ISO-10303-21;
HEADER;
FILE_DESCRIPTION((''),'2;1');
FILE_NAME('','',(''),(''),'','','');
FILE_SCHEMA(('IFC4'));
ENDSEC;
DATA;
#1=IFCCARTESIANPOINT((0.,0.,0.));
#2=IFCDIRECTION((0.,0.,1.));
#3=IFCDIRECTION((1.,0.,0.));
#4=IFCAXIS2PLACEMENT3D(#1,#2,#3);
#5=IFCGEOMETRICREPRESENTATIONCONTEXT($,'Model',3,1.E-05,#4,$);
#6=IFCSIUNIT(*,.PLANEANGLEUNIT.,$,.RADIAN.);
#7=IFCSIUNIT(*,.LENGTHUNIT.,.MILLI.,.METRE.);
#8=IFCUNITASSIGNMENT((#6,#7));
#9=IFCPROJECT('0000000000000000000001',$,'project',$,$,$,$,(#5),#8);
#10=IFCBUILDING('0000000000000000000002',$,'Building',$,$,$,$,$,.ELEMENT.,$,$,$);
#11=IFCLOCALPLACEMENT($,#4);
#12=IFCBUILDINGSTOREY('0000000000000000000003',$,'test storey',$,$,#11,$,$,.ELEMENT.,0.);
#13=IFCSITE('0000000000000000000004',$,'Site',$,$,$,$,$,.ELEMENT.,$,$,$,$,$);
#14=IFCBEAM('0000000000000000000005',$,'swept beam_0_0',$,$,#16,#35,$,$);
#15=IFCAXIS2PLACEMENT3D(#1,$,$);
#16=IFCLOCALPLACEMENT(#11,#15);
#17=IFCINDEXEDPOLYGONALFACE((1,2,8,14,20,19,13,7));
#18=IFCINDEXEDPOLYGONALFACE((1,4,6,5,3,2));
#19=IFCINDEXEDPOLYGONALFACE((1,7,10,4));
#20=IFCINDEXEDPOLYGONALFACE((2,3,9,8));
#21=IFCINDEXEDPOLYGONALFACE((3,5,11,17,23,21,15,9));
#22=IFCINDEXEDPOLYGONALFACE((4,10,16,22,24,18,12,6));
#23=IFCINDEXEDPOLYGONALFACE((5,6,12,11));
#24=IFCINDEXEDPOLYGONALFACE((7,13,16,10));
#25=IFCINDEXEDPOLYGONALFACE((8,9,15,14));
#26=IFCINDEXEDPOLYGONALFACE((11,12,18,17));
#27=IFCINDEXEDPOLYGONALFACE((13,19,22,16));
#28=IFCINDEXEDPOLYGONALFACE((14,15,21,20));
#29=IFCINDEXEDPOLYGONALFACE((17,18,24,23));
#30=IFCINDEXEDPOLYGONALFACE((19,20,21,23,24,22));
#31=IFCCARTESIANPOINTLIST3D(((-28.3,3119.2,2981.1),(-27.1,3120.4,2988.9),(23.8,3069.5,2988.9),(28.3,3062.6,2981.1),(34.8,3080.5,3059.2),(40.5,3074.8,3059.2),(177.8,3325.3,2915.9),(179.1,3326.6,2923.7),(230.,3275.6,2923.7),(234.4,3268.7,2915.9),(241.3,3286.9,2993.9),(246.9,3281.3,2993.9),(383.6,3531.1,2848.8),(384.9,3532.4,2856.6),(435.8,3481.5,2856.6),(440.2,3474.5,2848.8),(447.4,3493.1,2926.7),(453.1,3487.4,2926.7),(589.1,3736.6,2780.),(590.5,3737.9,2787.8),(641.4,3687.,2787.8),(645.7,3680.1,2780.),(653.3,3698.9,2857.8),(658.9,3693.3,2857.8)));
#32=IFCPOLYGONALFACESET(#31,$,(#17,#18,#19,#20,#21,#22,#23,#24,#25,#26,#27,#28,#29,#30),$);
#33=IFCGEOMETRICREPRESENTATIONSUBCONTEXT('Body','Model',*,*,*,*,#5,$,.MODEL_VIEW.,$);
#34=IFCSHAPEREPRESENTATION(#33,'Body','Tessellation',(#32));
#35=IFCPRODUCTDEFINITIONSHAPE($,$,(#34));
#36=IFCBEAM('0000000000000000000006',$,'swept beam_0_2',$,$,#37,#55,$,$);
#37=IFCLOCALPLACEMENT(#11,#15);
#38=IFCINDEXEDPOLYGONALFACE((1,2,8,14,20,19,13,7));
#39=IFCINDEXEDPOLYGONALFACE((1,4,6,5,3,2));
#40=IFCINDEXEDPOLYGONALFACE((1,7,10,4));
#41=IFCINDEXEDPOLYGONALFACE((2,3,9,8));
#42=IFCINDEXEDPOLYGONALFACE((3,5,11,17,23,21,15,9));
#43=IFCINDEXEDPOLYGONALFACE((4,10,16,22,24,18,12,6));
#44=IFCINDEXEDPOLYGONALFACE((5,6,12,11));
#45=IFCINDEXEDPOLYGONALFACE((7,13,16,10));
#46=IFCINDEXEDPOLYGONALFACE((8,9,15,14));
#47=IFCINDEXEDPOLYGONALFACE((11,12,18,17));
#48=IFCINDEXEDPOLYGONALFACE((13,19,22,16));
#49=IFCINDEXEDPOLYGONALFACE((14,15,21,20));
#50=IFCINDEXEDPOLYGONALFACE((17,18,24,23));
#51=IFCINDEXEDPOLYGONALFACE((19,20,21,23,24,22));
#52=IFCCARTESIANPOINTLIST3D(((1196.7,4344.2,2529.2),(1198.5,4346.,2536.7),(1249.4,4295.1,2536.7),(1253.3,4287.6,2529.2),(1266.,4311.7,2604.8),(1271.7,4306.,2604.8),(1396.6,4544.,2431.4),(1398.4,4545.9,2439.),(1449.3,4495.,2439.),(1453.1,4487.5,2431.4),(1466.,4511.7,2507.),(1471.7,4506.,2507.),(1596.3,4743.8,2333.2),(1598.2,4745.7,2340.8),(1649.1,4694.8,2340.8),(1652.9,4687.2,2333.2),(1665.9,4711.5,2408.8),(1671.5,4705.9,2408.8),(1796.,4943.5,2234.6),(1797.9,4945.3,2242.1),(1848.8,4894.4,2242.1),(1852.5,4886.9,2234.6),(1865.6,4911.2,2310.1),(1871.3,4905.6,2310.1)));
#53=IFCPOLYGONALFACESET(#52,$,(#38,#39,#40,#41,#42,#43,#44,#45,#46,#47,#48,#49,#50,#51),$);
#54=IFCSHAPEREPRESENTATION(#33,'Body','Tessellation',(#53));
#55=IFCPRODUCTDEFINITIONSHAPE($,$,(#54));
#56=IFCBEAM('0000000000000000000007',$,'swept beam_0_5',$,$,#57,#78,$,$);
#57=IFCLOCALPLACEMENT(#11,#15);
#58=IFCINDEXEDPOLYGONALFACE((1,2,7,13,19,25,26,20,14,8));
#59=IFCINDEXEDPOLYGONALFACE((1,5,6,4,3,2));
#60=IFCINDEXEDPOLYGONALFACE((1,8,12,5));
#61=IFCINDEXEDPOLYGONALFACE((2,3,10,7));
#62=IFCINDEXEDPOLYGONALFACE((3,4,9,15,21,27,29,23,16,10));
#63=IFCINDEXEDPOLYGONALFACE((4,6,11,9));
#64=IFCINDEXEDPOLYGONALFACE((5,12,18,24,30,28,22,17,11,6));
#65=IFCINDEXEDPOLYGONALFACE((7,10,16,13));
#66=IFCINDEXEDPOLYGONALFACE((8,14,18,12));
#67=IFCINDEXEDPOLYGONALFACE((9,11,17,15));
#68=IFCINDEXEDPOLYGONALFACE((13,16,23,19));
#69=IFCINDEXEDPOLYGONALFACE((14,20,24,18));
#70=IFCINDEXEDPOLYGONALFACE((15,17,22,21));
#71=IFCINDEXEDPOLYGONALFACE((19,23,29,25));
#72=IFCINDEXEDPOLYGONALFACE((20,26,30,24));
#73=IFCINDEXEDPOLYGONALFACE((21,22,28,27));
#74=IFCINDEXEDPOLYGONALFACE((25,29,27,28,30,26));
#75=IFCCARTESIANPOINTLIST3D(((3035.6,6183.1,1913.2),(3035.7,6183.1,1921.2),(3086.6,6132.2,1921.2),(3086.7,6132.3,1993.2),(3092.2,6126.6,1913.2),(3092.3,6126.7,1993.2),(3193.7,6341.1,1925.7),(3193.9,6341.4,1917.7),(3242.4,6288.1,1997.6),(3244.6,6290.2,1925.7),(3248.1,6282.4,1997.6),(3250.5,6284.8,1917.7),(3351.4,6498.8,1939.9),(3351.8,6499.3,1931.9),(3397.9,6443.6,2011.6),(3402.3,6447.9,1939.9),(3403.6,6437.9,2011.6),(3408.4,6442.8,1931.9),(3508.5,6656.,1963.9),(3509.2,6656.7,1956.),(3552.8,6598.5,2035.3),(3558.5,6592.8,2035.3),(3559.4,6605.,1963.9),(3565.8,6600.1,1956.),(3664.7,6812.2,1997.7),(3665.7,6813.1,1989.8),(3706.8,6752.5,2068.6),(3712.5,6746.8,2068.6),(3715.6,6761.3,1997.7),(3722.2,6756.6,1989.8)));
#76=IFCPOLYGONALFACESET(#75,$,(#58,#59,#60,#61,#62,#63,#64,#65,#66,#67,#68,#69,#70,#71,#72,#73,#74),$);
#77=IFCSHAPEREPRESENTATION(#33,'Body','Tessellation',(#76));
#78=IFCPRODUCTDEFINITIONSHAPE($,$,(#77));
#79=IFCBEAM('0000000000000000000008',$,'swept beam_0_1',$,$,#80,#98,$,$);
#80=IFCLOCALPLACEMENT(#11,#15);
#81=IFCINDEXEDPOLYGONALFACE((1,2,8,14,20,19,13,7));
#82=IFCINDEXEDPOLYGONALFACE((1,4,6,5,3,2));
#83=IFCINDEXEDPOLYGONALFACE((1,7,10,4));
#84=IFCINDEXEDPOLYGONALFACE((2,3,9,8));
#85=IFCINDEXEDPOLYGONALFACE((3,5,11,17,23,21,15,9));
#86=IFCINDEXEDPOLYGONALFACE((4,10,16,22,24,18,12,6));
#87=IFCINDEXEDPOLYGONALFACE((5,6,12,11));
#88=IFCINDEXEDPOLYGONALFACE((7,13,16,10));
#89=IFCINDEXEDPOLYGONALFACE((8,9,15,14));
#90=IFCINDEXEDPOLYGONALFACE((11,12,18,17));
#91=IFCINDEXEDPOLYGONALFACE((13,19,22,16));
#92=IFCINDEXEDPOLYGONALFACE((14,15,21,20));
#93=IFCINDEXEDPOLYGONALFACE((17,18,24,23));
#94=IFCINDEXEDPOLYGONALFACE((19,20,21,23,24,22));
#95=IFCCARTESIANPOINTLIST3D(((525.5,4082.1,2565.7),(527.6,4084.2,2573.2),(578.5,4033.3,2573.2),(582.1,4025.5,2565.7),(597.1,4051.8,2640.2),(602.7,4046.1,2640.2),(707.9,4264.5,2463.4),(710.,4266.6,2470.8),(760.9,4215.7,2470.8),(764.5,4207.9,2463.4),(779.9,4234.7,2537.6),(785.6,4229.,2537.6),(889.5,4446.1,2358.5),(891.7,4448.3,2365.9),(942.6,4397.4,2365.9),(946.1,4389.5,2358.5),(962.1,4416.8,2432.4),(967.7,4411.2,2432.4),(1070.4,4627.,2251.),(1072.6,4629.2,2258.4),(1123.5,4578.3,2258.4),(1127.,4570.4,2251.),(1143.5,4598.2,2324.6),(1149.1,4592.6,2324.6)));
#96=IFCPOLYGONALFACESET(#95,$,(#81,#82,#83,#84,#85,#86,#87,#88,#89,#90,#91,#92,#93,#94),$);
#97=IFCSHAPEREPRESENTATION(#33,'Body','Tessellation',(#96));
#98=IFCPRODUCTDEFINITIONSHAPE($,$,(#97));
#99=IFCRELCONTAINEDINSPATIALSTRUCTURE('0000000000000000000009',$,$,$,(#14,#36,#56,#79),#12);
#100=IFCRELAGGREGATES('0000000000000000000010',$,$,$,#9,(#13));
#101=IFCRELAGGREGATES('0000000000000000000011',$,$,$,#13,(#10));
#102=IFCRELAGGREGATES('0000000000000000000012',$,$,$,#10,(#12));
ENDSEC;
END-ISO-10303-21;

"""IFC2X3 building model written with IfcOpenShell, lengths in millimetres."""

from ifc_helpers import new_model, entity, si_unit, origin_with_axes, place, context, subcontext, project, spatial, element, save


model = new_model("IFC2X3")

# Units and contexts
model_context = context("Model", 3, precision=1e-05, world=origin_with_axes())
body_context = subcontext(model_context, "Body", "Model", "MODEL_VIEW")
ifc_project = project(units=[si_unit("PLANEANGLEUNIT", "RADIAN"), si_unit("LENGTHUNIT", "METRE", prefix="MILLI")], contexts=[model_context])

# Site, building, storey
site = spatial("IfcSite", under=ifc_project, Name="Site", CompositionType="ELEMENT")
building = spatial("IfcBuilding", under=site, Name="Building", CompositionType="ELEMENT")
storey_placement = place(None, origin_with_axes())
storey = spatial("IfcBuildingStorey", under=building, at=storey_placement, Name="test storey", CompositionType="ELEMENT", Elevation=0.0)

# Beams
beam_1_placement = place(storey_placement, origin_with_axes())
element("IfcBeam", 1, at=beam_1_placement, inside=storey, Name="swept beam_0_0", context=body_context, shape_type="SweptSolid", body=[
    entity("IfcRevolvedAreaSolid", entity("IfcArbitraryClosedProfileDef", "AREA", None, entity("IfcPolyline", [entity("IfcCartesianPoint", [80.0, -40.0]), entity("IfcCartesianPoint", [80.0, -32.0]), entity("IfcCartesianPoint", [8.0, -32.0]), entity("IfcCartesianPoint", [8.0, 40.0]), entity("IfcCartesianPoint", [0.0, 40.0]), entity("IfcCartesianPoint", [0.0, -40.0]), entity("IfcCartesianPoint", [80.0, -40.0])])), entity("IfcAxis2Placement3D", entity("IfcCartesianPoint", [0.0, 3090.9, 2981.1]), entity("IfcDirection", [-0.6905, -0.6905, 0.2152]), entity("IfcDirection", [0.1522, 0.1522, 0.9766])), entity("IfcAxis1Placement", entity("IfcCartesianPoint", [-47402.4, 0.0, 0.0]), entity("IfcDirection", [0.0, 1.0, 0.0])), 0.018903),
])
beam_2_placement = place(storey_placement, origin_with_axes())
element("IfcBeam", 2, at=beam_2_placement, inside=storey, Name="swept beam_0_2", context=body_context, shape_type="SweptSolid", body=[
    entity("IfcRevolvedAreaSolid", entity("IfcArbitraryClosedProfileDef", "AREA", None, entity("IfcPolyline", [entity("IfcCartesianPoint", [80.0, -40.0]), entity("IfcCartesianPoint", [80.0, -32.0]), entity("IfcCartesianPoint", [8.0, -32.0]), entity("IfcCartesianPoint", [8.0, 40.0]), entity("IfcCartesianPoint", [0.0, 40.0]), entity("IfcCartesianPoint", [0.0, -40.0]), entity("IfcCartesianPoint", [80.0, -40.0])])), entity("IfcAxis2Placement3D", entity("IfcCartesianPoint", [1225.0, 4315.9, 2529.2]), entity("IfcDirection", [-0.6685, -0.6685, 0.3261]), entity("IfcDirection", [0.2306, 0.2306, 0.9453])), entity("IfcAxis1Placement", entity("IfcCartesianPoint", [-187120.4, 0.0, 0.0]), entity("IfcDirection", [0.0, 1.0, 0.0])), 0.004795),
])
beam_3_placement = place(storey_placement, origin_with_axes())
element("IfcBeam", 3, at=beam_3_placement, inside=storey, Name="swept beam_0_5", context=body_context, shape_type="SweptSolid", body=[
    entity("IfcRevolvedAreaSolid", entity("IfcArbitraryClosedProfileDef", "AREA", None, entity("IfcPolyline", [entity("IfcCartesianPoint", [-80.0, 40.0]), entity("IfcCartesianPoint", [-80.0, 32.0]), entity("IfcCartesianPoint", [-8.0, 32.0]), entity("IfcCartesianPoint", [-8.0, -40.0]), entity("IfcCartesianPoint", [0.0, -40.0]), entity("IfcCartesianPoint", [0.0, 40.0]), entity("IfcCartesianPoint", [-80.0, 40.0])])), entity("IfcAxis2Placement3D", entity("IfcCartesianPoint", [3063.9, 6154.8, 1913.2]), entity("IfcDirection", [-0.7071, -0.7071, 0.0021]), entity("IfcDirection", [-0.0015, -0.0015, -1.0])), entity("IfcAxis1Placement", entity("IfcCartesianPoint", [-5100.2, 0.0, 0.0]), entity("IfcDirection", [0.0, 1.0, 0.0])), 0.175565),
])
beam_4_placement = place(storey_placement, origin_with_axes())
element("IfcBeam", 4, at=beam_4_placement, inside=storey, Name="swept beam_0_1", context=body_context, shape_type="SweptSolid", body=[
    entity("IfcRevolvedAreaSolid", entity("IfcArbitraryClosedProfileDef", "AREA", None, entity("IfcPolyline", [entity("IfcCartesianPoint", [80.0, -40.0]), entity("IfcCartesianPoint", [80.0, -32.0]), entity("IfcCartesianPoint", [8.0, -32.0]), entity("IfcCartesianPoint", [8.0, 40.0]), entity("IfcCartesianPoint", [0.0, 40.0]), entity("IfcCartesianPoint", [0.0, -40.0]), entity("IfcCartesianPoint", [80.0, -40.0])])), entity("IfcAxis2Placement3D", entity("IfcCartesianPoint", [553.8, 4053.8, 2565.7]), entity("IfcDirection", [-0.6586, -0.6586, 0.3642]), entity("IfcDirection", [0.2575, 0.2575, 0.9313])), entity("IfcAxis1Placement", entity("IfcCartesianPoint", [-27851.1, 0.0, 0.0]), entity("IfcDirection", [0.0, 1.0, 0.0])), 0.029886),
])

save(model, "model.ifc")
